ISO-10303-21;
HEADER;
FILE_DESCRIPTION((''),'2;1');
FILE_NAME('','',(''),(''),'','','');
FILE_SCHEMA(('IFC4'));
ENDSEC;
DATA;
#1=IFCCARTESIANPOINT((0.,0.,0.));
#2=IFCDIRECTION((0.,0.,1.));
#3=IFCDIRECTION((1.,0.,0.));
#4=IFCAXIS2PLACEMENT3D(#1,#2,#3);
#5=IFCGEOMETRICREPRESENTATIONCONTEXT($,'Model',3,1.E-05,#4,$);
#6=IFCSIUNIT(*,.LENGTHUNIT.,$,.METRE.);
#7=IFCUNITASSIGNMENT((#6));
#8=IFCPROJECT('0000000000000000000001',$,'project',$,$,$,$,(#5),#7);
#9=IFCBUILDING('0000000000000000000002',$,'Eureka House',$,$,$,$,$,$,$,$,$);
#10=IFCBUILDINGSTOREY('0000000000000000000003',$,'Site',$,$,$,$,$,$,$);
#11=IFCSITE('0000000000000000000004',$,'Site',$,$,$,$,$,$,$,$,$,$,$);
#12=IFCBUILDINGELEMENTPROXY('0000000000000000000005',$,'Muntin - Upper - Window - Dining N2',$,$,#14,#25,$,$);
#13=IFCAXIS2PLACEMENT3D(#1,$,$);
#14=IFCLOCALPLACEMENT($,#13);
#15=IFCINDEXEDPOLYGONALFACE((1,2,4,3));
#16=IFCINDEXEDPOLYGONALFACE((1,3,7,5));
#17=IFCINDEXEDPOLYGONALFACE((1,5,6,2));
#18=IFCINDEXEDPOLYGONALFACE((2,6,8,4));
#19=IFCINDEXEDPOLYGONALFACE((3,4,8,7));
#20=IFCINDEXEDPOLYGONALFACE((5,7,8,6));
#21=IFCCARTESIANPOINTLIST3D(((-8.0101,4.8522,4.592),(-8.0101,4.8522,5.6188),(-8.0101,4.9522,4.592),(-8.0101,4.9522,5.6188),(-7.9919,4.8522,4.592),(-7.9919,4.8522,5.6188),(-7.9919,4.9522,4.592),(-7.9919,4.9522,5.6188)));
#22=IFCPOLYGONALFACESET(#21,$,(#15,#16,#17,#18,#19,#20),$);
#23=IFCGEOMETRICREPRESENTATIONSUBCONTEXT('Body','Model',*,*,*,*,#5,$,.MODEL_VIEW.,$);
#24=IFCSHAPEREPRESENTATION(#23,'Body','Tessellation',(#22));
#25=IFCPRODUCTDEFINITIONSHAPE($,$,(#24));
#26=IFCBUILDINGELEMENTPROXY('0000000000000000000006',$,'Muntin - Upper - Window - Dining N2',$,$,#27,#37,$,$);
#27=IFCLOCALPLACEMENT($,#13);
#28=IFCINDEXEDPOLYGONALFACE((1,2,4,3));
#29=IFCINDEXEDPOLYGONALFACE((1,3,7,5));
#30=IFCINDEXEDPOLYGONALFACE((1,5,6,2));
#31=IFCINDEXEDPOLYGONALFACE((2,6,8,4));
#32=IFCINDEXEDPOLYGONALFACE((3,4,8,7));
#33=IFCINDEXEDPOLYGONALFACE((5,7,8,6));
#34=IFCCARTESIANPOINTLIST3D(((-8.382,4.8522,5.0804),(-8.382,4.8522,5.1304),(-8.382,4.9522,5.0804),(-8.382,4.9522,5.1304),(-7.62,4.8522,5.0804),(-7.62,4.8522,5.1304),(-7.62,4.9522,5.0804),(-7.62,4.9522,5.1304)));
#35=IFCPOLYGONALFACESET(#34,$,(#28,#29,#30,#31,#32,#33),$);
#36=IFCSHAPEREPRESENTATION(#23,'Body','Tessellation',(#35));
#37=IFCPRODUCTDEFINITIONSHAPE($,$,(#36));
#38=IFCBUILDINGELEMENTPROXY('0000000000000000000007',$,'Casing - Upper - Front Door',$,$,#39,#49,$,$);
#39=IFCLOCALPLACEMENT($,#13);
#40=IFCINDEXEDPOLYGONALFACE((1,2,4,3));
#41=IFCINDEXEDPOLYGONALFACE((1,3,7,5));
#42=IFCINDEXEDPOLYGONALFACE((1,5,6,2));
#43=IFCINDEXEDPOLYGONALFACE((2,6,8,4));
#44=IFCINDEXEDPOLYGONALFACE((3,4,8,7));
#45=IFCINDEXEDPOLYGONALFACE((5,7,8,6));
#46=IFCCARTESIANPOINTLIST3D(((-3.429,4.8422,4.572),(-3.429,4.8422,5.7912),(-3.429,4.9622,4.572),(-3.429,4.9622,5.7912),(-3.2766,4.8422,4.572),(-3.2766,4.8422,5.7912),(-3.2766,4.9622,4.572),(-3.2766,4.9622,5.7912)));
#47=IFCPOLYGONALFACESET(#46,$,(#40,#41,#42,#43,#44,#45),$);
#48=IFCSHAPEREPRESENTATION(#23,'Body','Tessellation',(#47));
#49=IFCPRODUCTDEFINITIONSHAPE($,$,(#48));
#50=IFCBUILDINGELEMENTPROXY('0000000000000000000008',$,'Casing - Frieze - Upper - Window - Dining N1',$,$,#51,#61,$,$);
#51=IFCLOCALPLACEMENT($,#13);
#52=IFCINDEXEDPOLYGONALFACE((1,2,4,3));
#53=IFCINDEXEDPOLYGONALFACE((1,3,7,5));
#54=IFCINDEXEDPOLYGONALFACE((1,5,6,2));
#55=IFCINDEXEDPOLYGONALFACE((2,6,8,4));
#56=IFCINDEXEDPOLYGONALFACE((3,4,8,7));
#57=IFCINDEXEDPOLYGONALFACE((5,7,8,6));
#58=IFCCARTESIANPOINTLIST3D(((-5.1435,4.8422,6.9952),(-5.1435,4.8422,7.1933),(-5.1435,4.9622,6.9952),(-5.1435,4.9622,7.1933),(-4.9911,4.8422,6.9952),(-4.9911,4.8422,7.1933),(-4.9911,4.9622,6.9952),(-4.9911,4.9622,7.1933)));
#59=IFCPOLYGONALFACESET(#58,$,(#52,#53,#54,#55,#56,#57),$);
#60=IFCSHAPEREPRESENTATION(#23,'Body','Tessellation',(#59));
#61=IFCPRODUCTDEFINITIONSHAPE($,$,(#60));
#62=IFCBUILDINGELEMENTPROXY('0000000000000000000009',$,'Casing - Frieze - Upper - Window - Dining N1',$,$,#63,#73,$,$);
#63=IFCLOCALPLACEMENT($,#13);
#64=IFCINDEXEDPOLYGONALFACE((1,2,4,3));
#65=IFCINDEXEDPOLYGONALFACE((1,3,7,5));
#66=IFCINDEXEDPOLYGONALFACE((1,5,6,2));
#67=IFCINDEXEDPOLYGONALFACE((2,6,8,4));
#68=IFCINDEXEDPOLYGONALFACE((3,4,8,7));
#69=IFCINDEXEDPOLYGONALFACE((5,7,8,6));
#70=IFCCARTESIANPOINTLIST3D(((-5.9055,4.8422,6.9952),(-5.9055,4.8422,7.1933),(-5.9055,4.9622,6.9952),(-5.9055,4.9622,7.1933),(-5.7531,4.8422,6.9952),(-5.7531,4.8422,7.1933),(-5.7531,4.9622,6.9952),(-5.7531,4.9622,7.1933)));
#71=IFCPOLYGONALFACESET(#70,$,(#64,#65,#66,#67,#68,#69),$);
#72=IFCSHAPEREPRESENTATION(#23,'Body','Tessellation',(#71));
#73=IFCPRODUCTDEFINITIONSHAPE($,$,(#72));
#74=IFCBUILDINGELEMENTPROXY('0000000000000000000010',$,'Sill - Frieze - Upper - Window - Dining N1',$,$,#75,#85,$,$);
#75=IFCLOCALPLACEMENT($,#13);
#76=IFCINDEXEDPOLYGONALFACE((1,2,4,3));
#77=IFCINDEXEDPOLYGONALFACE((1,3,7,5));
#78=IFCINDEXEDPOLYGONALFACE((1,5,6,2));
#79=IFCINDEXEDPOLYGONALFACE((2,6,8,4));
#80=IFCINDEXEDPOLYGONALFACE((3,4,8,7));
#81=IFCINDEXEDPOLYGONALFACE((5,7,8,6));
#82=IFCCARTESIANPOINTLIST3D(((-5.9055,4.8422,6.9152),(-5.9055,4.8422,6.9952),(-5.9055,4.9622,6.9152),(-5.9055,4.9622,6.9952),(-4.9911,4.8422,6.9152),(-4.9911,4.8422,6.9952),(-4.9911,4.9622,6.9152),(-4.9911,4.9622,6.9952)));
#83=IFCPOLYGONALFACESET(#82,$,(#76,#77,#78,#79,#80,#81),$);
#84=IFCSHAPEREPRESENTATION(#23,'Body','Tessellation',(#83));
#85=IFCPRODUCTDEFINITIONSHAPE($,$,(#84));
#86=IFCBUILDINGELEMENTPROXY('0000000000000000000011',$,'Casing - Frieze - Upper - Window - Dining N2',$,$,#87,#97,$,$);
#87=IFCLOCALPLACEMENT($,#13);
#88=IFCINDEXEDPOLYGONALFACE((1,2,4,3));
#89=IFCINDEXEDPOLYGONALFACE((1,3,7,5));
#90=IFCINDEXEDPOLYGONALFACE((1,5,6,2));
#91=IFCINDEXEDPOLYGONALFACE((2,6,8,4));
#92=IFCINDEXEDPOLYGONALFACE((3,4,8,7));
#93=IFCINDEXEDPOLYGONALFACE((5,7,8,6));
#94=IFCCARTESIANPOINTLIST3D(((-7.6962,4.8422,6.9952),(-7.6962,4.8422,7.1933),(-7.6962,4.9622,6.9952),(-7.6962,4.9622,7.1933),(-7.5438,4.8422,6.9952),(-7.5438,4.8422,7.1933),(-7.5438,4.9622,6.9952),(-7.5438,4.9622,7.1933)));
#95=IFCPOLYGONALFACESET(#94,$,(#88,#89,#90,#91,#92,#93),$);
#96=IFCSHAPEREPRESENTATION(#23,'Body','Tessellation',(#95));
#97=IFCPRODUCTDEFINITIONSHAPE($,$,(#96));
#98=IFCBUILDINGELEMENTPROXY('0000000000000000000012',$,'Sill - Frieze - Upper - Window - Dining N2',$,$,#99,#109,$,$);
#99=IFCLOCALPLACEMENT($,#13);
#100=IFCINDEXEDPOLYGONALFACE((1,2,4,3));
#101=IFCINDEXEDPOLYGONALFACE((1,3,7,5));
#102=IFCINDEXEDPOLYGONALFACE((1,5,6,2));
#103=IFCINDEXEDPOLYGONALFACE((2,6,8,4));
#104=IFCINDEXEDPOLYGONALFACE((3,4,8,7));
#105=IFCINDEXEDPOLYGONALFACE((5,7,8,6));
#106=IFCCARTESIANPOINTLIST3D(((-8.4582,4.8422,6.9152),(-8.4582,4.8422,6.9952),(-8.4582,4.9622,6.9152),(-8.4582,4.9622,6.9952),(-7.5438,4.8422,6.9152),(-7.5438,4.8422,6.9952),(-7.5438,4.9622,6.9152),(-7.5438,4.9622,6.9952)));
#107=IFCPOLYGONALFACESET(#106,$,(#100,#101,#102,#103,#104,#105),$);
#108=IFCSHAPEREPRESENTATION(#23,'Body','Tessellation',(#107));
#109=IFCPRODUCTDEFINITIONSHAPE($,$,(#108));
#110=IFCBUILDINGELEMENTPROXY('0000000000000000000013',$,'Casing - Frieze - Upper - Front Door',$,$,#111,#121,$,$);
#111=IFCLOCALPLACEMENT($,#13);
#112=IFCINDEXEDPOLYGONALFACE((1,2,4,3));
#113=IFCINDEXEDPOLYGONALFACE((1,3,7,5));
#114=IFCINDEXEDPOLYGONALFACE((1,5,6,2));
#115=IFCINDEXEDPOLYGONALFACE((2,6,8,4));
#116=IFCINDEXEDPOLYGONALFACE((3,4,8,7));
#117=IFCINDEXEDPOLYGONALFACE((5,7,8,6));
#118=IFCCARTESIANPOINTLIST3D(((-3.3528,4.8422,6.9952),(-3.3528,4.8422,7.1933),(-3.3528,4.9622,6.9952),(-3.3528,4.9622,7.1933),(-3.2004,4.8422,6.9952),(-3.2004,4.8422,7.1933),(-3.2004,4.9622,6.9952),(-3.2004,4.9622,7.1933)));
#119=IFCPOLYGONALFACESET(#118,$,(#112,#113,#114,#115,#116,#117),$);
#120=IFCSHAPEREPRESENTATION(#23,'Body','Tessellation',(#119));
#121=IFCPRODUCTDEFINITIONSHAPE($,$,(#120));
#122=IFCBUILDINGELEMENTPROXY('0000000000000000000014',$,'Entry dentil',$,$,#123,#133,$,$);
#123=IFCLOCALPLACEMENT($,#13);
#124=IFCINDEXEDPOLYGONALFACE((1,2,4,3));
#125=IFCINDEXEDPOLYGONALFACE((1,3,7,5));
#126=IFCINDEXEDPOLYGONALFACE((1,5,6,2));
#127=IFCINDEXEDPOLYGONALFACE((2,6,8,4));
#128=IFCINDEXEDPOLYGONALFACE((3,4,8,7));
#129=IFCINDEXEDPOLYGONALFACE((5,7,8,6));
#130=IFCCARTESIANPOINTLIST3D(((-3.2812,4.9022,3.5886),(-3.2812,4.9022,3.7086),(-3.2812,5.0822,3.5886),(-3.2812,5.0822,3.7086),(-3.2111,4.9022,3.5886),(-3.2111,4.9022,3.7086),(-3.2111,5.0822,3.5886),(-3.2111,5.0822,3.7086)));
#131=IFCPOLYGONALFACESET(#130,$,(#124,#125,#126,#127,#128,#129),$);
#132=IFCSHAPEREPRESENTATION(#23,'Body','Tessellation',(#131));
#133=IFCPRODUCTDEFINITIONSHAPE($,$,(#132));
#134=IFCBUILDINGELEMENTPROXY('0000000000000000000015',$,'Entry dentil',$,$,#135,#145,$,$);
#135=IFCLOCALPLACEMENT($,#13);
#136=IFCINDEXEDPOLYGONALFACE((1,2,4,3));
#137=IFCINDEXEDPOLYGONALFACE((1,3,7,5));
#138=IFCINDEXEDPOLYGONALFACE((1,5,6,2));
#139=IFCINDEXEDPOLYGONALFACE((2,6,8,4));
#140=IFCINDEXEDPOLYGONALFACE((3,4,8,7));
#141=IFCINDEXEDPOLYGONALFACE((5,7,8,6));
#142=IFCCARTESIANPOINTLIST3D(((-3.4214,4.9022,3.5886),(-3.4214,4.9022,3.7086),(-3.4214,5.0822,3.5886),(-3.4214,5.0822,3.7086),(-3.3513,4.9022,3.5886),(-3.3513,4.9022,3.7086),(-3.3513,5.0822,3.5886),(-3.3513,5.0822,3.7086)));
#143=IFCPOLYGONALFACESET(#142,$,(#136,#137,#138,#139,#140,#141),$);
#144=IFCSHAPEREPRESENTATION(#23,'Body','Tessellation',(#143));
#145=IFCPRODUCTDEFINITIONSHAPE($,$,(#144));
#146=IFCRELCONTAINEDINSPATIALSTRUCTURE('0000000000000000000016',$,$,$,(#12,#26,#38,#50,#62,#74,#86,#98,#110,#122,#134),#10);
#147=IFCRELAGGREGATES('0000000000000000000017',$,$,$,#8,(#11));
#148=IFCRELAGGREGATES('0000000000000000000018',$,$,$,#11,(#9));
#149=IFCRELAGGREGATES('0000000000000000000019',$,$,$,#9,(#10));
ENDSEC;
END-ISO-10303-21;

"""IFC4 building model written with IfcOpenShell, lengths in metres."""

from ifc_helpers import new_model, si_unit, frame, origin, origin_with_axes, origin_2d, place, context, subcontext, project, spatial, rectangle, extrude, element, save


model = new_model("IFC4")

# Units and contexts
model_context = context("Model", 3, precision=1e-05, world=origin_with_axes())
body_context = subcontext(model_context, "Body", "Model", "MODEL_VIEW")
ifc_project = project(units=[si_unit("LENGTHUNIT", "METRE")], contexts=[model_context])

# Site, building, storey
site = spatial("IfcSite", under=ifc_project, Name="Site")
building = spatial("IfcBuilding", under=site, Name="Eureka House")
storey = spatial("IfcBuildingStorey", under=building, Name="Site")

# Building element proxies
proxy_1_placement = place(None, frame((-8.001, 4.9022, 4.592), z_axis=(0.0, 0.0, 1.0), x_axis=(1.0, 0.0, 0.0)))
element("IfcBuildingElementProxy", 1, at=proxy_1_placement, inside=storey, Name="Muntin - Upper - Window - Dining N2", context=body_context, shape_type="SweptSolid", body=[
    extrude(rectangle(XDim=0.0183, YDim=0.1, at=origin_2d()), origin(), (0.0, 0.0, 1.0), 1.0268),
])
proxy_2_placement = place(None, frame((-8.001, 4.9022, 5.0804), z_axis=(0.0, 0.0, 1.0), x_axis=(1.0, 0.0, 0.0)))
element("IfcBuildingElementProxy", 2, at=proxy_2_placement, inside=storey, Name="Muntin - Upper - Window - Dining N2", context=body_context, shape_type="SweptSolid", body=[
    extrude(rectangle(XDim=0.762, YDim=0.1, at=origin_2d()), origin(), (0.0, 0.0, 1.0), 0.05),
])
proxy_3_placement = place(None, frame((-3.3528, 4.9022, 4.572), z_axis=(0.0, 0.0, 1.0), x_axis=(1.0, 0.0, 0.0)))
element("IfcBuildingElementProxy", 3, at=proxy_3_placement, inside=storey, Name="Casing - Upper - Front Door", context=body_context, shape_type="SweptSolid", body=[
    extrude(rectangle(XDim=0.1524, YDim=0.12, at=origin_2d()), origin(), (0.0, 0.0, 1.0), 1.2192),
])
for number, where, z_axis, x_axis, name in (
    (4, (-5.0673, 4.9022, 6.9952), (0.0, 0.0, 1.0), (1.0, 0.0, 0.0), "Casing - Frieze - Upper - Window - Dining N1"),
    (5, (-5.8293, 4.9022, 6.9952), (0.0, 0.0, 1.0), (1.0, 0.0, 0.0), "Casing - Frieze - Upper - Window - Dining N1"),
):
    element("IfcBuildingElementProxy", number, at=place(None, frame(where, z_axis=z_axis, x_axis=x_axis)), inside=storey, Name=name, context=body_context, shape_type="SweptSolid", body=[
        extrude(rectangle(XDim=0.1524, YDim=0.12, at=origin_2d()), origin(), (0.0, 0.0, 1.0), 0.1981),
    ])
proxy_4_placement = place(None, frame((-5.4483, 4.9022, 6.9152), z_axis=(0.0, 0.0, 1.0), x_axis=(1.0, 0.0, 0.0)))
element("IfcBuildingElementProxy", 6, at=proxy_4_placement, inside=storey, Name="Sill - Frieze - Upper - Window - Dining N1", context=body_context, shape_type="SweptSolid", body=[
    extrude(rectangle(XDim=0.9144, YDim=0.12, at=origin_2d()), origin(), (0.0, 0.0, 1.0), 0.08),
])
proxy_5_placement = place(None, frame((-7.62, 4.9022, 6.9952), z_axis=(0.0, 0.0, 1.0), x_axis=(1.0, 0.0, 0.0)))
element("IfcBuildingElementProxy", 7, at=proxy_5_placement, inside=storey, Name="Casing - Frieze - Upper - Window - Dining N2", context=body_context, shape_type="SweptSolid", body=[
    extrude(rectangle(XDim=0.1524, YDim=0.12, at=origin_2d()), origin(), (0.0, 0.0, 1.0), 0.1981),
])
proxy_6_placement = place(None, frame((-8.001, 4.9022, 6.9152), z_axis=(0.0, 0.0, 1.0), x_axis=(1.0, 0.0, 0.0)))
element("IfcBuildingElementProxy", 8, at=proxy_6_placement, inside=storey, Name="Sill - Frieze - Upper - Window - Dining N2", context=body_context, shape_type="SweptSolid", body=[
    extrude(rectangle(XDim=0.9144, YDim=0.12, at=origin_2d()), origin(), (0.0, 0.0, 1.0), 0.08),
])
proxy_7_placement = place(None, frame((-3.2766, 4.9022, 6.9952), z_axis=(0.0, 0.0, 1.0), x_axis=(1.0, 0.0, 0.0)))
element("IfcBuildingElementProxy", 9, at=proxy_7_placement, inside=storey, Name="Casing - Frieze - Upper - Front Door", context=body_context, shape_type="SweptSolid", body=[
    extrude(rectangle(XDim=0.1524, YDim=0.12, at=origin_2d()), origin(), (0.0, 0.0, 1.0), 0.1981),
])
for number, where, z_axis, x_axis, name in (
    (10, (-3.2461, 4.9922, 3.5886), (0.0, 0.0, 1.0), (1.0, 0.0, 0.0), "Entry dentil"),
    (11, (-3.3863, 4.9922, 3.5886), (0.0, 0.0, 1.0), (1.0, 0.0, 0.0), "Entry dentil"),
):
    element("IfcBuildingElementProxy", number, at=place(None, frame(where, z_axis=z_axis, x_axis=x_axis)), inside=storey, Name=name, context=body_context, shape_type="SweptSolid", body=[
        extrude(rectangle(XDim=0.0701, YDim=0.18, at=origin_2d()), origin(), (0.0, 0.0, 1.0), 0.12),
    ])

save(model, "model.ifc")
